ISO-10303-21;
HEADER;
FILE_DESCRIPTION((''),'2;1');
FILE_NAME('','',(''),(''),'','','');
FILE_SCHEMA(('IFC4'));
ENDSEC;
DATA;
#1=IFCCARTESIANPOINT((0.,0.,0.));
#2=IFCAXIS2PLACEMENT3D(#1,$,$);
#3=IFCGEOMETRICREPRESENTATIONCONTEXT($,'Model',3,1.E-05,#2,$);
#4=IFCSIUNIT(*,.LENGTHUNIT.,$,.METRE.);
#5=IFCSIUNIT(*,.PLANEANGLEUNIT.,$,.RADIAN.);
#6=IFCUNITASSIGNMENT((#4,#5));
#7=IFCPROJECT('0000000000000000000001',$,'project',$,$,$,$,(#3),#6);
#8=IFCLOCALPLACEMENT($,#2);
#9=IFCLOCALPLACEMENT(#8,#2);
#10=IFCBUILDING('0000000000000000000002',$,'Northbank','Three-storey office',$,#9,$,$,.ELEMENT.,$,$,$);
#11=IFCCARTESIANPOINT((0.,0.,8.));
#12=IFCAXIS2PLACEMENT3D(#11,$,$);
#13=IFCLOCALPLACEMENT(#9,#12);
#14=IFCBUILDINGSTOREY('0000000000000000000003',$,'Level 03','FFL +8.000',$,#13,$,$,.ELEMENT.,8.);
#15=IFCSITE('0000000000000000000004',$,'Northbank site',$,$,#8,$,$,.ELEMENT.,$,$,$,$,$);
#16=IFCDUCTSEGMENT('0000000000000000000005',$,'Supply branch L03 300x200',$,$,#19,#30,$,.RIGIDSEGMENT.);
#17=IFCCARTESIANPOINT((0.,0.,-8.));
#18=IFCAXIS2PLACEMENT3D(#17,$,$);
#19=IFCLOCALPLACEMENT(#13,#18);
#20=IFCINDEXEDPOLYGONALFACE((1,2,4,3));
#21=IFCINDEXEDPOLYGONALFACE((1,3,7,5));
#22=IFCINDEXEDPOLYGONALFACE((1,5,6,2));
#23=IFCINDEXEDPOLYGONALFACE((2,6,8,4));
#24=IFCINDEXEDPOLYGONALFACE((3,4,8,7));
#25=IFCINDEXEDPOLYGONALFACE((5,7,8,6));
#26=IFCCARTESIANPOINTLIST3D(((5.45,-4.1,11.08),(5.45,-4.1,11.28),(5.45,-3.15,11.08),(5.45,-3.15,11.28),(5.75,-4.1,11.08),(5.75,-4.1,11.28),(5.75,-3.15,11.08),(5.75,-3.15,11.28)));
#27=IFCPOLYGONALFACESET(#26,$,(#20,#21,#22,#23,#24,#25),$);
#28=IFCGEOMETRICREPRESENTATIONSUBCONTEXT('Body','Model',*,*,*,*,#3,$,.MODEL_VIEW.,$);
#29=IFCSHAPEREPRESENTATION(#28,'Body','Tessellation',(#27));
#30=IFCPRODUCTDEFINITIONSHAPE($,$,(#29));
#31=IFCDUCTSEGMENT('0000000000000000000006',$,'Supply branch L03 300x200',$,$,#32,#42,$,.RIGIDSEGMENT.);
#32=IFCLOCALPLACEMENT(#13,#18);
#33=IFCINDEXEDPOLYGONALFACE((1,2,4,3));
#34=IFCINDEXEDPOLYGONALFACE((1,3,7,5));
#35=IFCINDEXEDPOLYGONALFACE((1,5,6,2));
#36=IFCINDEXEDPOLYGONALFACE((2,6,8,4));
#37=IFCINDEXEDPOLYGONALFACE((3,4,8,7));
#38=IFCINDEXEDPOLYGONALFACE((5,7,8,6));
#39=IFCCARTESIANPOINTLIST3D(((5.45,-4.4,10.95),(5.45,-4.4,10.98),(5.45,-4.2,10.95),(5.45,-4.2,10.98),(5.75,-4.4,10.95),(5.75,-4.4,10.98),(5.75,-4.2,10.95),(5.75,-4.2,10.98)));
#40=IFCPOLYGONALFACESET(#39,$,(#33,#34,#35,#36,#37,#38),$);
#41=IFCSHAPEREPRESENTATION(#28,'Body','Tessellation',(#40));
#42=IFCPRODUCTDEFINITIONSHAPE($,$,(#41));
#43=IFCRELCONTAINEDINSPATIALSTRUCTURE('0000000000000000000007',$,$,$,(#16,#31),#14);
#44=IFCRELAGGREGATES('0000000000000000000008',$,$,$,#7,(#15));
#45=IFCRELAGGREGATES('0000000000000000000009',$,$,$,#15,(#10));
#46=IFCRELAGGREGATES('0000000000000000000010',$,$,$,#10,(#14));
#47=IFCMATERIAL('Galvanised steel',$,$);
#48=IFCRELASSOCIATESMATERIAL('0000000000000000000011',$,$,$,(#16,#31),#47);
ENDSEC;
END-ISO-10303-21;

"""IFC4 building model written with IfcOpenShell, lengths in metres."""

from ifc_helpers import new_model, si_unit, frame, origin, place, context, subcontext, project, spatial, rectangle, extrude, material, element, save


model = new_model("IFC4")

# Units and contexts
model_context = context("Model", 3, precision=1e-05, world=origin())
body_context = subcontext(model_context, "Body", "Model", "MODEL_VIEW")
ifc_project = project(units=[si_unit("LENGTHUNIT", "METRE"), si_unit("PLANEANGLEUNIT", "RADIAN")], contexts=[model_context])

# Site, building, storey
site_placement = place(None, origin())
site = spatial("IfcSite", under=ifc_project, at=site_placement, Name="Northbank site", CompositionType="ELEMENT")
building_placement = place(site_placement, origin())
building = spatial("IfcBuilding", under=site, at=building_placement, Name="Northbank", Description="Three-storey office", CompositionType="ELEMENT")
storey_placement = place(building_placement, frame((0.0, 0.0, 8.0)))
storey = spatial("IfcBuildingStorey", under=building, at=storey_placement, Name="Level 03", Description="FFL +8.000", CompositionType="ELEMENT", Elevation=8.0)

# Shared definitions
ifc_material_1 = material(Name="Galvanised steel")

# Duct segments
duct_segment_1_placement = place(storey_placement, frame((0.0, 0.0, -8.0)))
element("IfcDuctSegment", 1, at=duct_segment_1_placement, inside=storey, material=ifc_material_1, Name="Supply branch L03 300x200", PredefinedType="RIGIDSEGMENT", context=body_context, shape_type="SweptSolid", body=[
    extrude(rectangle(XDim=0.3, YDim=0.2), frame((5.6, -3.15, 11.18), z_axis=(0.0, -1.0, 0.0), x_axis=(1.0, 0.0, 0.0)), (0.0, 0.0, 1.0), 0.95),
])
duct_segment_2_placement = place(storey_placement, frame((0.0, 0.0, -8.0)))
element("IfcDuctSegment", 2, at=duct_segment_2_placement, inside=storey, material=ifc_material_1, Name="Supply branch L03 300x200", PredefinedType="RIGIDSEGMENT", context=body_context, shape_type="SweptSolid", body=[
    extrude(rectangle(XDim=0.3, YDim=0.2), frame((5.6, -4.3, 10.98), z_axis=(0.0, 0.0, -1.0), x_axis=(1.0, 0.0, 0.0)), (0.0, 0.0, 1.0), 0.03),
])

save(model, "model.ifc")
